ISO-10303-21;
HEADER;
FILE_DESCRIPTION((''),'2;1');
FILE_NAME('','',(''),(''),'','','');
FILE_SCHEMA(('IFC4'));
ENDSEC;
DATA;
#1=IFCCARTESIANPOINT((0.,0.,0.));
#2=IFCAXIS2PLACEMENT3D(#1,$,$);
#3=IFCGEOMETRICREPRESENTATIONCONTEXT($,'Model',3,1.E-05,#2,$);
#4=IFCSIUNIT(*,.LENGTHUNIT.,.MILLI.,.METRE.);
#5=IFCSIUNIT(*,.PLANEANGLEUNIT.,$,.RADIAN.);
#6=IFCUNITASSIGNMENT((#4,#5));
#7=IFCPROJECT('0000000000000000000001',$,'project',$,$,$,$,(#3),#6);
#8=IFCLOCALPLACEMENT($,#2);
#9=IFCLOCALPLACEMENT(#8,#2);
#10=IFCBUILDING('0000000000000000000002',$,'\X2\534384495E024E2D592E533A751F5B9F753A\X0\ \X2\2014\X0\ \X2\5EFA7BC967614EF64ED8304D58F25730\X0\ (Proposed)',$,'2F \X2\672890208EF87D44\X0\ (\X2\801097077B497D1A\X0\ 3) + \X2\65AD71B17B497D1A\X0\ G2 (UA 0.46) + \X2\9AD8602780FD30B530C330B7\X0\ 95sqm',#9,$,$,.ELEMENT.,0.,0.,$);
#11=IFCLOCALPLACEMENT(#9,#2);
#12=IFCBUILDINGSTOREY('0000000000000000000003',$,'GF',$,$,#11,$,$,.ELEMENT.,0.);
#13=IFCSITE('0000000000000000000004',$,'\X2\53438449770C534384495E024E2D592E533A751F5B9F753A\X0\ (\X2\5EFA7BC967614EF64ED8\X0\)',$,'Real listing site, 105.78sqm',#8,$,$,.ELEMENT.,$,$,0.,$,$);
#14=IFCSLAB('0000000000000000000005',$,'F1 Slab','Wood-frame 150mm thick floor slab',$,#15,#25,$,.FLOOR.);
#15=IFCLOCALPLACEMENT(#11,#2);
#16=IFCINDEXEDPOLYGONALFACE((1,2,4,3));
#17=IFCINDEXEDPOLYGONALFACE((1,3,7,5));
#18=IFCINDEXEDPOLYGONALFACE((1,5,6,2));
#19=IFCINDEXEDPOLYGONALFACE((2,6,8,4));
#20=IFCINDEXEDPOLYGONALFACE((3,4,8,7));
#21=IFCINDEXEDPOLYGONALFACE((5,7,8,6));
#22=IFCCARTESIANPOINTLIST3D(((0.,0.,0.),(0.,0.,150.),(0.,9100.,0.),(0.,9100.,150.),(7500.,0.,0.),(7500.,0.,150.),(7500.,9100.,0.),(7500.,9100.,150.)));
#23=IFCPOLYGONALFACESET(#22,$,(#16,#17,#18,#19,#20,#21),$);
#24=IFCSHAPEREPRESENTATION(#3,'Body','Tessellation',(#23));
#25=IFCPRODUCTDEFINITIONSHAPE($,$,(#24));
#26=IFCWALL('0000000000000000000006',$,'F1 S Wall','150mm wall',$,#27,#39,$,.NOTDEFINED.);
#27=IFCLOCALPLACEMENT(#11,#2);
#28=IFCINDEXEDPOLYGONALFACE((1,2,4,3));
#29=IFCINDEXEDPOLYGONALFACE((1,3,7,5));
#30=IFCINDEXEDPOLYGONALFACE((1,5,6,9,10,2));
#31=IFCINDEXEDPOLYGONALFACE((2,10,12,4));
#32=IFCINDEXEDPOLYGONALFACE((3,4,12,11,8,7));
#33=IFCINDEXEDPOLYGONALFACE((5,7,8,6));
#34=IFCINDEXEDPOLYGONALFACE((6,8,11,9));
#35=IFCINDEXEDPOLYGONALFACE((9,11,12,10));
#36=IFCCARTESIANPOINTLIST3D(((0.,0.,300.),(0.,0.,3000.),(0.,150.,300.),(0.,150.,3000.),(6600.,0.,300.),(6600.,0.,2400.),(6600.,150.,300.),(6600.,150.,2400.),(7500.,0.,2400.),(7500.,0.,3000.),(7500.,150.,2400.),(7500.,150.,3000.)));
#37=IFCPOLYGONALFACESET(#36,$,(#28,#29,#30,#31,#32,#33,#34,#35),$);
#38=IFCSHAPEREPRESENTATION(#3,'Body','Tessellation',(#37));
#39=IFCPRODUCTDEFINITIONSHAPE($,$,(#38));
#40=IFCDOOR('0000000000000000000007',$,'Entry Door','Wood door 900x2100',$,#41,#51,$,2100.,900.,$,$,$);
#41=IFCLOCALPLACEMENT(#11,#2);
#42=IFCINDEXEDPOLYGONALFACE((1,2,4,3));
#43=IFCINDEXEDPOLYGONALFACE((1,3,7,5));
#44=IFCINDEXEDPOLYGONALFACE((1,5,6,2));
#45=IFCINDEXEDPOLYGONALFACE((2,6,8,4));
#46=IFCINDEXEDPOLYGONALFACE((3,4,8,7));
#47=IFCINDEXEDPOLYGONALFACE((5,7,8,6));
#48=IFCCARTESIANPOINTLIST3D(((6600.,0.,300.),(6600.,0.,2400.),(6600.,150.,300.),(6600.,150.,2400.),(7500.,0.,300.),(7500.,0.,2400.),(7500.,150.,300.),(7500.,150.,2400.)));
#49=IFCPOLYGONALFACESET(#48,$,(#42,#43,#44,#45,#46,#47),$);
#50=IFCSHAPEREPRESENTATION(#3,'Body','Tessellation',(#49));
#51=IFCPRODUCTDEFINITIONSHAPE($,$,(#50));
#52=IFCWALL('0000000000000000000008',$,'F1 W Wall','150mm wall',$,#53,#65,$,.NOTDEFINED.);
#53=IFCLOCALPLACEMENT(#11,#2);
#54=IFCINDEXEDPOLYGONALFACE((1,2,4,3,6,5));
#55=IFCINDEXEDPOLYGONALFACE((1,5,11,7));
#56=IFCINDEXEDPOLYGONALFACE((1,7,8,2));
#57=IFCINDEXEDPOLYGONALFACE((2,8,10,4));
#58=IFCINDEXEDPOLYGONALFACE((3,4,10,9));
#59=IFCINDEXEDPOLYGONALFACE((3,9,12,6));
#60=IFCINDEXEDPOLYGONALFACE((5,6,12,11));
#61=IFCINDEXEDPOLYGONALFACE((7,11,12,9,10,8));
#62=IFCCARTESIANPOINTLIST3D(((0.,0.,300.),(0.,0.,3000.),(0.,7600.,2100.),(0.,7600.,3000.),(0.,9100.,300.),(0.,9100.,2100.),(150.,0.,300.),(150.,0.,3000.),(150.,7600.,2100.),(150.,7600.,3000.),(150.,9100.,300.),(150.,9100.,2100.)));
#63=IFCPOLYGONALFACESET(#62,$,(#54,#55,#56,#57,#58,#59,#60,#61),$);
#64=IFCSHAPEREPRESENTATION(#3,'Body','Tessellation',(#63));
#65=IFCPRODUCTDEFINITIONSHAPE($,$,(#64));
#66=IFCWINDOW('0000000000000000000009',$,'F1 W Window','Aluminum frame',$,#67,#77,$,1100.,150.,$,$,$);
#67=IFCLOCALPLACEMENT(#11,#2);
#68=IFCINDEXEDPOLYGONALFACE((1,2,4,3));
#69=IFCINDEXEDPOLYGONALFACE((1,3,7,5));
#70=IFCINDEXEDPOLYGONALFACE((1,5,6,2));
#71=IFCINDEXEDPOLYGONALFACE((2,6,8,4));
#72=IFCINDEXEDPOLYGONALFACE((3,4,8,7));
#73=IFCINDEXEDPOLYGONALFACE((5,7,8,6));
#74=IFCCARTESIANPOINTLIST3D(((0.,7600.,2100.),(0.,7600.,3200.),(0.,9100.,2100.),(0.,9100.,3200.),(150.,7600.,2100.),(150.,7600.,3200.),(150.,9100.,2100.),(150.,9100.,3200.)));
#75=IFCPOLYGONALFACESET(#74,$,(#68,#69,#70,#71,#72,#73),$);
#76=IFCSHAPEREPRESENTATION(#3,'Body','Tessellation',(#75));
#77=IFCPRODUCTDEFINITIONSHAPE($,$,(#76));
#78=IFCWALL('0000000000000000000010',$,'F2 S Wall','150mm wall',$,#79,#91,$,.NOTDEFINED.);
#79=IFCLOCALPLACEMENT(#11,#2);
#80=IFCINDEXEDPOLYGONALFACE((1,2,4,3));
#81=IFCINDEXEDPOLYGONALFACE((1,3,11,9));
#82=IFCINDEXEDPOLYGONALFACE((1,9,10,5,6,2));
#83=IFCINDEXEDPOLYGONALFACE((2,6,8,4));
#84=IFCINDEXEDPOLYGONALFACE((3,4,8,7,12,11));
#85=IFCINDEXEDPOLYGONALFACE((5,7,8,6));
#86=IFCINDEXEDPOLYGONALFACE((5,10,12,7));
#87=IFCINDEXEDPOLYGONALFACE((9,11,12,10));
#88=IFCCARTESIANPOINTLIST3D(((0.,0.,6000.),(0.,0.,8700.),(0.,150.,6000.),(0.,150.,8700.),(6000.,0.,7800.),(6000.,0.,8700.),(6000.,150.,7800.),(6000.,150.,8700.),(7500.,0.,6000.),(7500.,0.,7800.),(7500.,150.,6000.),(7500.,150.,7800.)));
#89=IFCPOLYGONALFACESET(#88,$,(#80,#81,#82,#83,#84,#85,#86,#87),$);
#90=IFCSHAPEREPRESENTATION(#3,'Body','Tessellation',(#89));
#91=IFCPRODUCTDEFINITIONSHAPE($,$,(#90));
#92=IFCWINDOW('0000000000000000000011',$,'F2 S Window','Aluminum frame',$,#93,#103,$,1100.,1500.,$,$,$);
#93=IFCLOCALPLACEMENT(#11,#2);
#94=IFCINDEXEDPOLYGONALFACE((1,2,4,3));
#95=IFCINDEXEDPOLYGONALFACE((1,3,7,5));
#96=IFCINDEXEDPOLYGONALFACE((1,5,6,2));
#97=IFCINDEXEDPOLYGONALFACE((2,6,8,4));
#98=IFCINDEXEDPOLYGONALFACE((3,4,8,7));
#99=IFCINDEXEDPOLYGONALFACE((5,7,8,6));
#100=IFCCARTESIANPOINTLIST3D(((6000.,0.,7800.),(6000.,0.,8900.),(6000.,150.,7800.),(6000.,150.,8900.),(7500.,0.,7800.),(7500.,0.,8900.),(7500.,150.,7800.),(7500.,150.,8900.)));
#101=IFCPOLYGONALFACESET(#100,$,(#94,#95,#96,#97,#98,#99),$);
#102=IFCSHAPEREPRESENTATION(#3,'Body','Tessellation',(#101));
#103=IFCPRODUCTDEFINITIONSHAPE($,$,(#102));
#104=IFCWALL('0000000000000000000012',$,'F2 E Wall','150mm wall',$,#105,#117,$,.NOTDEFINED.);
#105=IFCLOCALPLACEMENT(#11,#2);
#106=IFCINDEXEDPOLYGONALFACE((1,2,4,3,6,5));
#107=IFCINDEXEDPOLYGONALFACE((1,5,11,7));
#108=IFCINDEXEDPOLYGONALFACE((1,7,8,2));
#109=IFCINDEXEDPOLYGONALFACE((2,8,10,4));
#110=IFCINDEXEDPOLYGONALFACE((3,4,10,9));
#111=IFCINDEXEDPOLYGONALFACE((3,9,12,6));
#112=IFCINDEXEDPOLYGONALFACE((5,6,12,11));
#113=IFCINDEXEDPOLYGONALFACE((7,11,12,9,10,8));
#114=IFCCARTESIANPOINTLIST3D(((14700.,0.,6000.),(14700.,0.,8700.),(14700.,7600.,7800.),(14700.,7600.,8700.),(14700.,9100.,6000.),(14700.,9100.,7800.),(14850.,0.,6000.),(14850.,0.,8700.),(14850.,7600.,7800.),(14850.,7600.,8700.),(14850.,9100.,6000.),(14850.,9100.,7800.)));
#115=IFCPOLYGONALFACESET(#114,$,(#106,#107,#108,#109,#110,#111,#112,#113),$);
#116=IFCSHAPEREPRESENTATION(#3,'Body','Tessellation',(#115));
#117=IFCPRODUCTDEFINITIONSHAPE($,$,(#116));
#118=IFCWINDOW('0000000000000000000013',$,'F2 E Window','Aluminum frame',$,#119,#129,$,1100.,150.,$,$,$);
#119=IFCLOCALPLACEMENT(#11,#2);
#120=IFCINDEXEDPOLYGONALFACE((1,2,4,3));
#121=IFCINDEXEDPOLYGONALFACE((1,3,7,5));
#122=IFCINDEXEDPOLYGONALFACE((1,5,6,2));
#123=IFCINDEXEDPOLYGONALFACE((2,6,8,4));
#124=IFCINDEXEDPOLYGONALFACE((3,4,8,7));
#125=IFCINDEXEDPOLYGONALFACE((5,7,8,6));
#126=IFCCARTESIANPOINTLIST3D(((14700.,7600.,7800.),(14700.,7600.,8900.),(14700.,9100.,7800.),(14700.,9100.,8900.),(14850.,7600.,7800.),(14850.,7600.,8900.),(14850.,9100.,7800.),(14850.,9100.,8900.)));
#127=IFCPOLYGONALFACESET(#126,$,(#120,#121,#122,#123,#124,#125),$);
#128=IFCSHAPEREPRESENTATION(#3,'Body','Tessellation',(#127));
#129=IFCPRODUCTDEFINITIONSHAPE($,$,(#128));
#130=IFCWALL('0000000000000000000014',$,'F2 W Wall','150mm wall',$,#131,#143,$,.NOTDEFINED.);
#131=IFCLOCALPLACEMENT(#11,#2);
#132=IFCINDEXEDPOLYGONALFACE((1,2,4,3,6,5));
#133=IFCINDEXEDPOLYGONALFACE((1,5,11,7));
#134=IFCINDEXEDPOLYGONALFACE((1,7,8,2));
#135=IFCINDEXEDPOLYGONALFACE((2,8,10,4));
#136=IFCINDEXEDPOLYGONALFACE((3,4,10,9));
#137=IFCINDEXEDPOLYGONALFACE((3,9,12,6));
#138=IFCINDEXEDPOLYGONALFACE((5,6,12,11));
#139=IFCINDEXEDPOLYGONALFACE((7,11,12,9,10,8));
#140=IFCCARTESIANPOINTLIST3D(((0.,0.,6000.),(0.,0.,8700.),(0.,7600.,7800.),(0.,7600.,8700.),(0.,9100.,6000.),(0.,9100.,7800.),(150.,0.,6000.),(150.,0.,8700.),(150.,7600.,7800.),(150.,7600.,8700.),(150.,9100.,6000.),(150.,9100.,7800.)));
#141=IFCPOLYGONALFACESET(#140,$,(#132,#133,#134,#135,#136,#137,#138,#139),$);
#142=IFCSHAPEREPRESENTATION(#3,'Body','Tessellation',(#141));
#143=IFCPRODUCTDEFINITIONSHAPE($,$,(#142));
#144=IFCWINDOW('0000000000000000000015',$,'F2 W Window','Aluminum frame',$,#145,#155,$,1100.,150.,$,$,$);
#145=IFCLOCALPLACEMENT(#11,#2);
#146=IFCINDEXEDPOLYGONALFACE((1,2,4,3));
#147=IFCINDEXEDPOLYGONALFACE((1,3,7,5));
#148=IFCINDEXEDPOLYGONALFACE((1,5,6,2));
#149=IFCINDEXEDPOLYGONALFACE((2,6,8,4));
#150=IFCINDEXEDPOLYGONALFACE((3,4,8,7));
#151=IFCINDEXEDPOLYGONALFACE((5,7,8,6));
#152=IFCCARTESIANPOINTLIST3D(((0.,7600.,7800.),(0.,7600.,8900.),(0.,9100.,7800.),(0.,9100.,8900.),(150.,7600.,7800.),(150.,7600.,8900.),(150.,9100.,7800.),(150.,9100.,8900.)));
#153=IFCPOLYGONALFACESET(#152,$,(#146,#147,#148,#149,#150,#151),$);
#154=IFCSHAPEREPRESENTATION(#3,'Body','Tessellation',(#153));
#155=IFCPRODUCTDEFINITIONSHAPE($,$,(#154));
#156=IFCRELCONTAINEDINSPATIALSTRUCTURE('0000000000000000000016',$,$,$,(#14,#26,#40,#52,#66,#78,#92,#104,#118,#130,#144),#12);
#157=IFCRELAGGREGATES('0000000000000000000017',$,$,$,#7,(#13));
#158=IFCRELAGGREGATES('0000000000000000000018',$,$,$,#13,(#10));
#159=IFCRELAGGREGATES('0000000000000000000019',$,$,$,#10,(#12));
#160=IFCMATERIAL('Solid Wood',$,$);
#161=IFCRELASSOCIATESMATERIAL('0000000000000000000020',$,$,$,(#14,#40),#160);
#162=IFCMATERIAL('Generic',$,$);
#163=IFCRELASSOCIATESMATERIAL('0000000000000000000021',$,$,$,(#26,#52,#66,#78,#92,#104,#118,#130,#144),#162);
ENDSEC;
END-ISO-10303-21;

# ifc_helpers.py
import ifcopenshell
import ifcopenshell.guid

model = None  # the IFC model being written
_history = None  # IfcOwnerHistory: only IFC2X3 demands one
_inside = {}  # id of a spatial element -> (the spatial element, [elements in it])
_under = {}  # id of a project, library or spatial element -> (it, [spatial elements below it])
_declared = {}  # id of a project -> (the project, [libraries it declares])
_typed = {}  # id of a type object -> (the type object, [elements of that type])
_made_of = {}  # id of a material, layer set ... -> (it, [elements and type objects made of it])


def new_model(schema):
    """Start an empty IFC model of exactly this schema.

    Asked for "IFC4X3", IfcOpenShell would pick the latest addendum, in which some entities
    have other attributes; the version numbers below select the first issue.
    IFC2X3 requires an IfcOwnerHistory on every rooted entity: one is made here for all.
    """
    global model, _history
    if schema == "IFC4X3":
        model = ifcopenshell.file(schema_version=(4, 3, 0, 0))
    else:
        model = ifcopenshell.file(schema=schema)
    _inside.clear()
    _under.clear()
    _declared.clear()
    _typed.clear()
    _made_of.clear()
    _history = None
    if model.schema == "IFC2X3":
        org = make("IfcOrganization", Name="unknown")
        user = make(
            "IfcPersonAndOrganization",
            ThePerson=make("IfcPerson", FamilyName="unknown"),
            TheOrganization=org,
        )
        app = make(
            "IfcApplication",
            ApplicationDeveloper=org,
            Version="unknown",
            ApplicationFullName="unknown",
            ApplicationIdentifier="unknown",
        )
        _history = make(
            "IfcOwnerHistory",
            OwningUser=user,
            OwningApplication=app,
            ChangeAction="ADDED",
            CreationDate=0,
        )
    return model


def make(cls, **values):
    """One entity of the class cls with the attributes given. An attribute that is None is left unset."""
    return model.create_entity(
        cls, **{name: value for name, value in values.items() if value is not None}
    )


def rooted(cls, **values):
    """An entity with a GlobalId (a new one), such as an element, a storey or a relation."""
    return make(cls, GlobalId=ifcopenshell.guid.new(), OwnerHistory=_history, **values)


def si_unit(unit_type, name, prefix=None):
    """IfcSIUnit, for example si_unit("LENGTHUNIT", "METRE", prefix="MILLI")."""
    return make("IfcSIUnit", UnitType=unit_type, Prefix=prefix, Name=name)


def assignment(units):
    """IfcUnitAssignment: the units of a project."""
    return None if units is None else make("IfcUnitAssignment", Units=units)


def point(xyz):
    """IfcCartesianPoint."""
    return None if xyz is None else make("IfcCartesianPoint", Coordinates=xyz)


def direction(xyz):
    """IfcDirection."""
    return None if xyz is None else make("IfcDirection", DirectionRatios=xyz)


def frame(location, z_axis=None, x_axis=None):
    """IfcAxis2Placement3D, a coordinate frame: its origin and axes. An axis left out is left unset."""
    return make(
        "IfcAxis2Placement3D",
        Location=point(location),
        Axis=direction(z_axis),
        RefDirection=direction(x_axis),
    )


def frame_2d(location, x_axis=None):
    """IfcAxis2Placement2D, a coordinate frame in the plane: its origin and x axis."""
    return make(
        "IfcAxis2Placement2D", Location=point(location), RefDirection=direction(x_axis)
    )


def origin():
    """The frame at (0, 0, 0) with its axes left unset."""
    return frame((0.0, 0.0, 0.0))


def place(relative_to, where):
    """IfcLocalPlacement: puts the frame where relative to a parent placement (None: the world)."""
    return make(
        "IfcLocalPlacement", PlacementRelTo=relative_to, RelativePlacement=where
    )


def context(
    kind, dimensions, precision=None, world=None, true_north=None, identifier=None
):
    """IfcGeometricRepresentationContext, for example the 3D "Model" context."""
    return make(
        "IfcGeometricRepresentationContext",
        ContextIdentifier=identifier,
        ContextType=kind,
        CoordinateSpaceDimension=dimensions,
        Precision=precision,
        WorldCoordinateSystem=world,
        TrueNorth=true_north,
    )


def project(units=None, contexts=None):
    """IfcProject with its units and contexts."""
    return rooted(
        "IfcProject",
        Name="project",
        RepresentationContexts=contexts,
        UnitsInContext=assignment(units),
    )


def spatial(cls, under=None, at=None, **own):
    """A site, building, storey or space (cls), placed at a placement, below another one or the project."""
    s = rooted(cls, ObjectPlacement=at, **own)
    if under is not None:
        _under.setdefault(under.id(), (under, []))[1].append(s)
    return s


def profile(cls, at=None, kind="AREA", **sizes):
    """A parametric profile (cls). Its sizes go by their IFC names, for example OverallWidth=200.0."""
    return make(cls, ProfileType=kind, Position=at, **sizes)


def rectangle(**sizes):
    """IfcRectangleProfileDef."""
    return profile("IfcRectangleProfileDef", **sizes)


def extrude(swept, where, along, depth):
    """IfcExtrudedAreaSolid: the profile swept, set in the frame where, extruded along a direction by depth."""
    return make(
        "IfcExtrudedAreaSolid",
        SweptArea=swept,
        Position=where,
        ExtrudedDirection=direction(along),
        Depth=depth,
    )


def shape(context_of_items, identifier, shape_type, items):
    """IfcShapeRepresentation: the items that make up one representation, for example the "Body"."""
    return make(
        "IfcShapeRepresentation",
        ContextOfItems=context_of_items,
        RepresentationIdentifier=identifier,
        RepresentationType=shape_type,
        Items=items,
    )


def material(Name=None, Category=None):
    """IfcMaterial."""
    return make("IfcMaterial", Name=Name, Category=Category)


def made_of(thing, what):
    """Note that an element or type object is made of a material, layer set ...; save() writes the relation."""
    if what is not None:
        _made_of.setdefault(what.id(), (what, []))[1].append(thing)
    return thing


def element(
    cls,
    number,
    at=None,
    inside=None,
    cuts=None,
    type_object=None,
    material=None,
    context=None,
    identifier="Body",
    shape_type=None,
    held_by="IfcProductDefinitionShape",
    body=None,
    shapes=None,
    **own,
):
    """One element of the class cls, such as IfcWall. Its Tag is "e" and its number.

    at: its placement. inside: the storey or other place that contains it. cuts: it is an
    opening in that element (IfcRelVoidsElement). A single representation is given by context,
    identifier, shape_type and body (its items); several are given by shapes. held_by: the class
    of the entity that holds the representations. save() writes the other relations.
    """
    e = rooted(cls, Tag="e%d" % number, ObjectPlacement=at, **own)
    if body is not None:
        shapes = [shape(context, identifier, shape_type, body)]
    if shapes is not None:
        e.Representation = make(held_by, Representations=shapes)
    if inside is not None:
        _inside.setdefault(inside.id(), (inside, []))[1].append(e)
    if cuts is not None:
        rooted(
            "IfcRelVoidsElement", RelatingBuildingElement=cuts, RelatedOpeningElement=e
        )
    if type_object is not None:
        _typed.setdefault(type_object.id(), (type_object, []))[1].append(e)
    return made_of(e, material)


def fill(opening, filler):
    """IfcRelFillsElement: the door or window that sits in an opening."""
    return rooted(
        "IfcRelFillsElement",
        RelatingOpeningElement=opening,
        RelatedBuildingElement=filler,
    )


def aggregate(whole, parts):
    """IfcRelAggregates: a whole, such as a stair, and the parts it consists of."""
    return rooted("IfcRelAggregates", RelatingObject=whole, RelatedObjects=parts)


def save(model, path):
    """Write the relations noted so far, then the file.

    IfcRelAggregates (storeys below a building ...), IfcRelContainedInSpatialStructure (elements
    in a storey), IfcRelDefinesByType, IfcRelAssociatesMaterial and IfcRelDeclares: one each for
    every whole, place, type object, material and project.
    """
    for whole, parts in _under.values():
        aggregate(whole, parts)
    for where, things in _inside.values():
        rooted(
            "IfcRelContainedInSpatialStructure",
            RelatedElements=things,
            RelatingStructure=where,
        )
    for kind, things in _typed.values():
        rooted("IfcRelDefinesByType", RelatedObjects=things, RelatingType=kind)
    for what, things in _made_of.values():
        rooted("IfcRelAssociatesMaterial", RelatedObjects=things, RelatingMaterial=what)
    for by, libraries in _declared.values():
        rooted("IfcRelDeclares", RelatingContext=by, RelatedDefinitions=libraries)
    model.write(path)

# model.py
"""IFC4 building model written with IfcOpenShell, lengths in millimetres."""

from ifc_helpers import new_model, si_unit, frame, frame_2d, origin, place, context, project, spatial, rectangle, extrude, material, element, fill, save


model = new_model("IFC4")

# Units and contexts
model_context = context("Model", 3, precision=1e-05, world=origin())
ifc_project = project(units=[si_unit("LENGTHUNIT", "METRE", prefix="MILLI"), si_unit("PLANEANGLEUNIT", "RADIAN")], contexts=[model_context])

# Site, building, storey
site_placement = place(None, origin())
site = spatial("IfcSite", under=ifc_project, at=site_placement, Name="千葉県千葉市中央区生実町 (建築条件付)", ObjectType="Real listing site, 105.78sqm", CompositionType="ELEMENT", RefElevation=0.0)
building_placement = place(site_placement, origin())
building = spatial("IfcBuilding", under=site, at=building_placement, Name="千葉市中央区生実町 — 建築条件付き売地 (Proposed)", ObjectType="2F 木造軸組 (耐震等級 3) + 断熱等級 G2 (UA 0.46) + 高性能サッシ 95sqm", CompositionType="ELEMENT", ElevationOfRefHeight=0.0, ElevationOfTerrain=0.0)
storey_placement = place(building_placement, origin())
storey = spatial("IfcBuildingStorey", under=building, at=storey_placement, Name="GF", CompositionType="ELEMENT", Elevation=0.0)

# Slab
ifc_material_1 = material(Name="Solid Wood")
slab_1_placement = place(storey_placement, origin())
element("IfcSlab", 1, at=slab_1_placement, inside=storey, material=ifc_material_1, Name="F1 Slab", Description="Wood-frame 150mm thick floor slab", PredefinedType="FLOOR", context=model_context, shape_type="SweptSolid", body=[
    extrude(rectangle(XDim=7500.0, YDim=9100.0, at=frame_2d((3750.0, 4550.0))), origin(), (0.0, 0.0, 1.0), 150.0),
])

# Shared definitions
ifc_material_2 = material(Name="Generic")

# Wall, opening, door
wall_1_placement = place(storey_placement, frame((0.0, 0.0, 150.0)))
wall_1 = element("IfcWall", 2, at=wall_1_placement, inside=storey, material=ifc_material_2, Name="F1 S Wall", Description="150mm wall", PredefinedType="NOTDEFINED", context=model_context, shape_type="SweptSolid", body=[
    extrude(rectangle(XDim=7500.0, YDim=150.0, at=frame_2d((3750.0, 75.0))), frame((0.0, 0.0, 150.0)), (0.0, 0.0, 1.0), 2700.0),
])
opening_1_placement = place(storey_placement, frame((3300.0, 0.0, 150.0)))
opening_1 = element("IfcOpeningElement", 3, at=opening_1_placement, cuts=wall_1, PredefinedType="NOTDEFINED", context=model_context, shape_type="SweptSolid", body=[
    extrude(rectangle(XDim=900.0, YDim=150.0, at=frame_2d((450.0, 75.0))), frame((3300.0, 0.0, 150.0)), (0.0, 0.0, 1.0), 2100.0),
])
door_placement = place(storey_placement, frame((3300.0, 0.0, 150.0)))
door = element("IfcDoor", 4, at=door_placement, inside=storey, material=ifc_material_1, Name="Entry Door", Description="Wood door 900x2100", OverallHeight=2100.0, OverallWidth=900.0, context=model_context, shape_type="SweptSolid", body=[
    extrude(rectangle(XDim=900.0, YDim=150.0, at=frame_2d((450.0, 75.0))), frame((3300.0, 0.0, 150.0)), (0.0, 0.0, 1.0), 2100.0),
])
fill(opening_1, door)

# Walls, openings, windows
wall_2_placement = place(storey_placement, frame((0.0, 0.0, 150.0)))
wall_2 = element("IfcWall", 5, at=wall_2_placement, inside=storey, material=ifc_material_2, Name="F1 W Wall", Description="150mm wall", PredefinedType="NOTDEFINED", context=model_context, shape_type="SweptSolid", body=[
    extrude(rectangle(XDim=150.0, YDim=9100.0, at=frame_2d((75.0, 4550.0))), frame((0.0, 0.0, 150.0)), (0.0, 0.0, 1.0), 2700.0),
])
opening_2_placement = place(storey_placement, frame((0.0, 3800.0, 1050.0)))
opening_2 = element("IfcOpeningElement", 6, at=opening_2_placement, cuts=wall_2, PredefinedType="NOTDEFINED", context=model_context, shape_type="SweptSolid", body=[
    extrude(rectangle(XDim=150.0, YDim=1500.0, at=frame_2d((75.0, 750.0))), frame((0.0, 3800.0, 1050.0)), (0.0, 0.0, 1.0), 1100.0),
])
window_1_placement = place(storey_placement, frame((0.0, 3800.0, 1050.0)))
window_1 = element("IfcWindow", 7, at=window_1_placement, inside=storey, material=ifc_material_2, Name="F1 W Window", Description="Aluminum frame", OverallHeight=1100.0, OverallWidth=150.0, context=model_context, shape_type="SweptSolid", body=[
    extrude(rectangle(XDim=150.0, YDim=1500.0, at=frame_2d((75.0, 750.0))), frame((0.0, 3800.0, 1050.0)), (0.0, 0.0, 1.0), 1100.0),
])
fill(opening_2, window_1)
wall_3_placement = place(storey_placement, frame((0.0, 0.0, 3000.0)))
wall_3 = element("IfcWall", 8, at=wall_3_placement, inside=storey, material=ifc_material_2, Name="F2 S Wall", Description="150mm wall", PredefinedType="NOTDEFINED", context=model_context, shape_type="SweptSolid", body=[
    extrude(rectangle(XDim=7500.0, YDim=150.0, at=frame_2d((3750.0, 75.0))), frame((0.0, 0.0, 3000.0)), (0.0, 0.0, 1.0), 2700.0),
])
opening_3_placement = place(storey_placement, frame((3000.0, 0.0, 3900.0)))
opening_3 = element("IfcOpeningElement", 9, at=opening_3_placement, cuts=wall_3, PredefinedType="NOTDEFINED", context=model_context, shape_type="SweptSolid", body=[
    extrude(rectangle(XDim=1500.0, YDim=150.0, at=frame_2d((750.0, 75.0))), frame((3000.0, 0.0, 3900.0)), (0.0, 0.0, 1.0), 1100.0),
])
window_2_placement = place(storey_placement, frame((3000.0, 0.0, 3900.0)))
window_2 = element("IfcWindow", 10, at=window_2_placement, inside=storey, material=ifc_material_2, Name="F2 S Window", Description="Aluminum frame", OverallHeight=1100.0, OverallWidth=1500.0, context=model_context, shape_type="SweptSolid", body=[
    extrude(rectangle(XDim=1500.0, YDim=150.0, at=frame_2d((750.0, 75.0))), frame((3000.0, 0.0, 3900.0)), (0.0, 0.0, 1.0), 1100.0),
])
fill(opening_3, window_2)
wall_4_placement = place(storey_placement, frame((7350.0, 0.0, 3000.0)))
wall_4 = element("IfcWall", 11, at=wall_4_placement, inside=storey, material=ifc_material_2, Name="F2 E Wall", Description="150mm wall", PredefinedType="NOTDEFINED", context=model_context, shape_type="SweptSolid", body=[
    extrude(rectangle(XDim=150.0, YDim=9100.0, at=frame_2d((75.0, 4550.0))), frame((7350.0, 0.0, 3000.0)), (0.0, 0.0, 1.0), 2700.0),
])
opening_4_placement = place(storey_placement, frame((7350.0, 3800.0, 3900.0)))
opening_4 = element("IfcOpeningElement", 12, at=opening_4_placement, cuts=wall_4, PredefinedType="NOTDEFINED", context=model_context, shape_type="SweptSolid", body=[
    extrude(rectangle(XDim=150.0, YDim=1500.0, at=frame_2d((75.0, 750.0))), frame((7350.0, 3800.0, 3900.0)), (0.0, 0.0, 1.0), 1100.0),
])
window_3_placement = place(storey_placement, frame((7350.0, 3800.0, 3900.0)))
window_3 = element("IfcWindow", 13, at=window_3_placement, inside=storey, material=ifc_material_2, Name="F2 E Window", Description="Aluminum frame", OverallHeight=1100.0, OverallWidth=150.0, context=model_context, shape_type="SweptSolid", body=[
    extrude(rectangle(XDim=150.0, YDim=1500.0, at=frame_2d((75.0, 750.0))), frame((7350.0, 3800.0, 3900.0)), (0.0, 0.0, 1.0), 1100.0),
])
fill(opening_4, window_3)
wall_5_placement = place(storey_placement, frame((0.0, 0.0, 3000.0)))
wall_5 = element("IfcWall", 14, at=wall_5_placement, inside=storey, material=ifc_material_2, Name="F2 W Wall", Description="150mm wall", PredefinedType="NOTDEFINED", context=model_context, shape_type="SweptSolid", body=[
    extrude(rectangle(XDim=150.0, YDim=9100.0, at=frame_2d((75.0, 4550.0))), frame((0.0, 0.0, 3000.0)), (0.0, 0.0, 1.0), 2700.0),
])
opening_5_placement = place(storey_placement, frame((0.0, 3800.0, 3900.0)))
opening_5 = element("IfcOpeningElement", 15, at=opening_5_placement, cuts=wall_5, PredefinedType="NOTDEFINED", context=model_context, shape_type="SweptSolid", body=[
    extrude(rectangle(XDim=150.0, YDim=1500.0, at=frame_2d((75.0, 750.0))), frame((0.0, 3800.0, 3900.0)), (0.0, 0.0, 1.0), 1100.0),
])
window_4_placement = place(storey_placement, frame((0.0, 3800.0, 3900.0)))
window_4 = element("IfcWindow", 16, at=window_4_placement, inside=storey, material=ifc_material_2, Name="F2 W Window", Description="Aluminum frame", OverallHeight=1100.0, OverallWidth=150.0, context=model_context, shape_type="SweptSolid", body=[
    extrude(rectangle(XDim=150.0, YDim=1500.0, at=frame_2d((75.0, 750.0))), frame((0.0, 3800.0, 3900.0)), (0.0, 0.0, 1.0), 1100.0),
])
fill(opening_5, window_4)

save(model, "model.ifc")
